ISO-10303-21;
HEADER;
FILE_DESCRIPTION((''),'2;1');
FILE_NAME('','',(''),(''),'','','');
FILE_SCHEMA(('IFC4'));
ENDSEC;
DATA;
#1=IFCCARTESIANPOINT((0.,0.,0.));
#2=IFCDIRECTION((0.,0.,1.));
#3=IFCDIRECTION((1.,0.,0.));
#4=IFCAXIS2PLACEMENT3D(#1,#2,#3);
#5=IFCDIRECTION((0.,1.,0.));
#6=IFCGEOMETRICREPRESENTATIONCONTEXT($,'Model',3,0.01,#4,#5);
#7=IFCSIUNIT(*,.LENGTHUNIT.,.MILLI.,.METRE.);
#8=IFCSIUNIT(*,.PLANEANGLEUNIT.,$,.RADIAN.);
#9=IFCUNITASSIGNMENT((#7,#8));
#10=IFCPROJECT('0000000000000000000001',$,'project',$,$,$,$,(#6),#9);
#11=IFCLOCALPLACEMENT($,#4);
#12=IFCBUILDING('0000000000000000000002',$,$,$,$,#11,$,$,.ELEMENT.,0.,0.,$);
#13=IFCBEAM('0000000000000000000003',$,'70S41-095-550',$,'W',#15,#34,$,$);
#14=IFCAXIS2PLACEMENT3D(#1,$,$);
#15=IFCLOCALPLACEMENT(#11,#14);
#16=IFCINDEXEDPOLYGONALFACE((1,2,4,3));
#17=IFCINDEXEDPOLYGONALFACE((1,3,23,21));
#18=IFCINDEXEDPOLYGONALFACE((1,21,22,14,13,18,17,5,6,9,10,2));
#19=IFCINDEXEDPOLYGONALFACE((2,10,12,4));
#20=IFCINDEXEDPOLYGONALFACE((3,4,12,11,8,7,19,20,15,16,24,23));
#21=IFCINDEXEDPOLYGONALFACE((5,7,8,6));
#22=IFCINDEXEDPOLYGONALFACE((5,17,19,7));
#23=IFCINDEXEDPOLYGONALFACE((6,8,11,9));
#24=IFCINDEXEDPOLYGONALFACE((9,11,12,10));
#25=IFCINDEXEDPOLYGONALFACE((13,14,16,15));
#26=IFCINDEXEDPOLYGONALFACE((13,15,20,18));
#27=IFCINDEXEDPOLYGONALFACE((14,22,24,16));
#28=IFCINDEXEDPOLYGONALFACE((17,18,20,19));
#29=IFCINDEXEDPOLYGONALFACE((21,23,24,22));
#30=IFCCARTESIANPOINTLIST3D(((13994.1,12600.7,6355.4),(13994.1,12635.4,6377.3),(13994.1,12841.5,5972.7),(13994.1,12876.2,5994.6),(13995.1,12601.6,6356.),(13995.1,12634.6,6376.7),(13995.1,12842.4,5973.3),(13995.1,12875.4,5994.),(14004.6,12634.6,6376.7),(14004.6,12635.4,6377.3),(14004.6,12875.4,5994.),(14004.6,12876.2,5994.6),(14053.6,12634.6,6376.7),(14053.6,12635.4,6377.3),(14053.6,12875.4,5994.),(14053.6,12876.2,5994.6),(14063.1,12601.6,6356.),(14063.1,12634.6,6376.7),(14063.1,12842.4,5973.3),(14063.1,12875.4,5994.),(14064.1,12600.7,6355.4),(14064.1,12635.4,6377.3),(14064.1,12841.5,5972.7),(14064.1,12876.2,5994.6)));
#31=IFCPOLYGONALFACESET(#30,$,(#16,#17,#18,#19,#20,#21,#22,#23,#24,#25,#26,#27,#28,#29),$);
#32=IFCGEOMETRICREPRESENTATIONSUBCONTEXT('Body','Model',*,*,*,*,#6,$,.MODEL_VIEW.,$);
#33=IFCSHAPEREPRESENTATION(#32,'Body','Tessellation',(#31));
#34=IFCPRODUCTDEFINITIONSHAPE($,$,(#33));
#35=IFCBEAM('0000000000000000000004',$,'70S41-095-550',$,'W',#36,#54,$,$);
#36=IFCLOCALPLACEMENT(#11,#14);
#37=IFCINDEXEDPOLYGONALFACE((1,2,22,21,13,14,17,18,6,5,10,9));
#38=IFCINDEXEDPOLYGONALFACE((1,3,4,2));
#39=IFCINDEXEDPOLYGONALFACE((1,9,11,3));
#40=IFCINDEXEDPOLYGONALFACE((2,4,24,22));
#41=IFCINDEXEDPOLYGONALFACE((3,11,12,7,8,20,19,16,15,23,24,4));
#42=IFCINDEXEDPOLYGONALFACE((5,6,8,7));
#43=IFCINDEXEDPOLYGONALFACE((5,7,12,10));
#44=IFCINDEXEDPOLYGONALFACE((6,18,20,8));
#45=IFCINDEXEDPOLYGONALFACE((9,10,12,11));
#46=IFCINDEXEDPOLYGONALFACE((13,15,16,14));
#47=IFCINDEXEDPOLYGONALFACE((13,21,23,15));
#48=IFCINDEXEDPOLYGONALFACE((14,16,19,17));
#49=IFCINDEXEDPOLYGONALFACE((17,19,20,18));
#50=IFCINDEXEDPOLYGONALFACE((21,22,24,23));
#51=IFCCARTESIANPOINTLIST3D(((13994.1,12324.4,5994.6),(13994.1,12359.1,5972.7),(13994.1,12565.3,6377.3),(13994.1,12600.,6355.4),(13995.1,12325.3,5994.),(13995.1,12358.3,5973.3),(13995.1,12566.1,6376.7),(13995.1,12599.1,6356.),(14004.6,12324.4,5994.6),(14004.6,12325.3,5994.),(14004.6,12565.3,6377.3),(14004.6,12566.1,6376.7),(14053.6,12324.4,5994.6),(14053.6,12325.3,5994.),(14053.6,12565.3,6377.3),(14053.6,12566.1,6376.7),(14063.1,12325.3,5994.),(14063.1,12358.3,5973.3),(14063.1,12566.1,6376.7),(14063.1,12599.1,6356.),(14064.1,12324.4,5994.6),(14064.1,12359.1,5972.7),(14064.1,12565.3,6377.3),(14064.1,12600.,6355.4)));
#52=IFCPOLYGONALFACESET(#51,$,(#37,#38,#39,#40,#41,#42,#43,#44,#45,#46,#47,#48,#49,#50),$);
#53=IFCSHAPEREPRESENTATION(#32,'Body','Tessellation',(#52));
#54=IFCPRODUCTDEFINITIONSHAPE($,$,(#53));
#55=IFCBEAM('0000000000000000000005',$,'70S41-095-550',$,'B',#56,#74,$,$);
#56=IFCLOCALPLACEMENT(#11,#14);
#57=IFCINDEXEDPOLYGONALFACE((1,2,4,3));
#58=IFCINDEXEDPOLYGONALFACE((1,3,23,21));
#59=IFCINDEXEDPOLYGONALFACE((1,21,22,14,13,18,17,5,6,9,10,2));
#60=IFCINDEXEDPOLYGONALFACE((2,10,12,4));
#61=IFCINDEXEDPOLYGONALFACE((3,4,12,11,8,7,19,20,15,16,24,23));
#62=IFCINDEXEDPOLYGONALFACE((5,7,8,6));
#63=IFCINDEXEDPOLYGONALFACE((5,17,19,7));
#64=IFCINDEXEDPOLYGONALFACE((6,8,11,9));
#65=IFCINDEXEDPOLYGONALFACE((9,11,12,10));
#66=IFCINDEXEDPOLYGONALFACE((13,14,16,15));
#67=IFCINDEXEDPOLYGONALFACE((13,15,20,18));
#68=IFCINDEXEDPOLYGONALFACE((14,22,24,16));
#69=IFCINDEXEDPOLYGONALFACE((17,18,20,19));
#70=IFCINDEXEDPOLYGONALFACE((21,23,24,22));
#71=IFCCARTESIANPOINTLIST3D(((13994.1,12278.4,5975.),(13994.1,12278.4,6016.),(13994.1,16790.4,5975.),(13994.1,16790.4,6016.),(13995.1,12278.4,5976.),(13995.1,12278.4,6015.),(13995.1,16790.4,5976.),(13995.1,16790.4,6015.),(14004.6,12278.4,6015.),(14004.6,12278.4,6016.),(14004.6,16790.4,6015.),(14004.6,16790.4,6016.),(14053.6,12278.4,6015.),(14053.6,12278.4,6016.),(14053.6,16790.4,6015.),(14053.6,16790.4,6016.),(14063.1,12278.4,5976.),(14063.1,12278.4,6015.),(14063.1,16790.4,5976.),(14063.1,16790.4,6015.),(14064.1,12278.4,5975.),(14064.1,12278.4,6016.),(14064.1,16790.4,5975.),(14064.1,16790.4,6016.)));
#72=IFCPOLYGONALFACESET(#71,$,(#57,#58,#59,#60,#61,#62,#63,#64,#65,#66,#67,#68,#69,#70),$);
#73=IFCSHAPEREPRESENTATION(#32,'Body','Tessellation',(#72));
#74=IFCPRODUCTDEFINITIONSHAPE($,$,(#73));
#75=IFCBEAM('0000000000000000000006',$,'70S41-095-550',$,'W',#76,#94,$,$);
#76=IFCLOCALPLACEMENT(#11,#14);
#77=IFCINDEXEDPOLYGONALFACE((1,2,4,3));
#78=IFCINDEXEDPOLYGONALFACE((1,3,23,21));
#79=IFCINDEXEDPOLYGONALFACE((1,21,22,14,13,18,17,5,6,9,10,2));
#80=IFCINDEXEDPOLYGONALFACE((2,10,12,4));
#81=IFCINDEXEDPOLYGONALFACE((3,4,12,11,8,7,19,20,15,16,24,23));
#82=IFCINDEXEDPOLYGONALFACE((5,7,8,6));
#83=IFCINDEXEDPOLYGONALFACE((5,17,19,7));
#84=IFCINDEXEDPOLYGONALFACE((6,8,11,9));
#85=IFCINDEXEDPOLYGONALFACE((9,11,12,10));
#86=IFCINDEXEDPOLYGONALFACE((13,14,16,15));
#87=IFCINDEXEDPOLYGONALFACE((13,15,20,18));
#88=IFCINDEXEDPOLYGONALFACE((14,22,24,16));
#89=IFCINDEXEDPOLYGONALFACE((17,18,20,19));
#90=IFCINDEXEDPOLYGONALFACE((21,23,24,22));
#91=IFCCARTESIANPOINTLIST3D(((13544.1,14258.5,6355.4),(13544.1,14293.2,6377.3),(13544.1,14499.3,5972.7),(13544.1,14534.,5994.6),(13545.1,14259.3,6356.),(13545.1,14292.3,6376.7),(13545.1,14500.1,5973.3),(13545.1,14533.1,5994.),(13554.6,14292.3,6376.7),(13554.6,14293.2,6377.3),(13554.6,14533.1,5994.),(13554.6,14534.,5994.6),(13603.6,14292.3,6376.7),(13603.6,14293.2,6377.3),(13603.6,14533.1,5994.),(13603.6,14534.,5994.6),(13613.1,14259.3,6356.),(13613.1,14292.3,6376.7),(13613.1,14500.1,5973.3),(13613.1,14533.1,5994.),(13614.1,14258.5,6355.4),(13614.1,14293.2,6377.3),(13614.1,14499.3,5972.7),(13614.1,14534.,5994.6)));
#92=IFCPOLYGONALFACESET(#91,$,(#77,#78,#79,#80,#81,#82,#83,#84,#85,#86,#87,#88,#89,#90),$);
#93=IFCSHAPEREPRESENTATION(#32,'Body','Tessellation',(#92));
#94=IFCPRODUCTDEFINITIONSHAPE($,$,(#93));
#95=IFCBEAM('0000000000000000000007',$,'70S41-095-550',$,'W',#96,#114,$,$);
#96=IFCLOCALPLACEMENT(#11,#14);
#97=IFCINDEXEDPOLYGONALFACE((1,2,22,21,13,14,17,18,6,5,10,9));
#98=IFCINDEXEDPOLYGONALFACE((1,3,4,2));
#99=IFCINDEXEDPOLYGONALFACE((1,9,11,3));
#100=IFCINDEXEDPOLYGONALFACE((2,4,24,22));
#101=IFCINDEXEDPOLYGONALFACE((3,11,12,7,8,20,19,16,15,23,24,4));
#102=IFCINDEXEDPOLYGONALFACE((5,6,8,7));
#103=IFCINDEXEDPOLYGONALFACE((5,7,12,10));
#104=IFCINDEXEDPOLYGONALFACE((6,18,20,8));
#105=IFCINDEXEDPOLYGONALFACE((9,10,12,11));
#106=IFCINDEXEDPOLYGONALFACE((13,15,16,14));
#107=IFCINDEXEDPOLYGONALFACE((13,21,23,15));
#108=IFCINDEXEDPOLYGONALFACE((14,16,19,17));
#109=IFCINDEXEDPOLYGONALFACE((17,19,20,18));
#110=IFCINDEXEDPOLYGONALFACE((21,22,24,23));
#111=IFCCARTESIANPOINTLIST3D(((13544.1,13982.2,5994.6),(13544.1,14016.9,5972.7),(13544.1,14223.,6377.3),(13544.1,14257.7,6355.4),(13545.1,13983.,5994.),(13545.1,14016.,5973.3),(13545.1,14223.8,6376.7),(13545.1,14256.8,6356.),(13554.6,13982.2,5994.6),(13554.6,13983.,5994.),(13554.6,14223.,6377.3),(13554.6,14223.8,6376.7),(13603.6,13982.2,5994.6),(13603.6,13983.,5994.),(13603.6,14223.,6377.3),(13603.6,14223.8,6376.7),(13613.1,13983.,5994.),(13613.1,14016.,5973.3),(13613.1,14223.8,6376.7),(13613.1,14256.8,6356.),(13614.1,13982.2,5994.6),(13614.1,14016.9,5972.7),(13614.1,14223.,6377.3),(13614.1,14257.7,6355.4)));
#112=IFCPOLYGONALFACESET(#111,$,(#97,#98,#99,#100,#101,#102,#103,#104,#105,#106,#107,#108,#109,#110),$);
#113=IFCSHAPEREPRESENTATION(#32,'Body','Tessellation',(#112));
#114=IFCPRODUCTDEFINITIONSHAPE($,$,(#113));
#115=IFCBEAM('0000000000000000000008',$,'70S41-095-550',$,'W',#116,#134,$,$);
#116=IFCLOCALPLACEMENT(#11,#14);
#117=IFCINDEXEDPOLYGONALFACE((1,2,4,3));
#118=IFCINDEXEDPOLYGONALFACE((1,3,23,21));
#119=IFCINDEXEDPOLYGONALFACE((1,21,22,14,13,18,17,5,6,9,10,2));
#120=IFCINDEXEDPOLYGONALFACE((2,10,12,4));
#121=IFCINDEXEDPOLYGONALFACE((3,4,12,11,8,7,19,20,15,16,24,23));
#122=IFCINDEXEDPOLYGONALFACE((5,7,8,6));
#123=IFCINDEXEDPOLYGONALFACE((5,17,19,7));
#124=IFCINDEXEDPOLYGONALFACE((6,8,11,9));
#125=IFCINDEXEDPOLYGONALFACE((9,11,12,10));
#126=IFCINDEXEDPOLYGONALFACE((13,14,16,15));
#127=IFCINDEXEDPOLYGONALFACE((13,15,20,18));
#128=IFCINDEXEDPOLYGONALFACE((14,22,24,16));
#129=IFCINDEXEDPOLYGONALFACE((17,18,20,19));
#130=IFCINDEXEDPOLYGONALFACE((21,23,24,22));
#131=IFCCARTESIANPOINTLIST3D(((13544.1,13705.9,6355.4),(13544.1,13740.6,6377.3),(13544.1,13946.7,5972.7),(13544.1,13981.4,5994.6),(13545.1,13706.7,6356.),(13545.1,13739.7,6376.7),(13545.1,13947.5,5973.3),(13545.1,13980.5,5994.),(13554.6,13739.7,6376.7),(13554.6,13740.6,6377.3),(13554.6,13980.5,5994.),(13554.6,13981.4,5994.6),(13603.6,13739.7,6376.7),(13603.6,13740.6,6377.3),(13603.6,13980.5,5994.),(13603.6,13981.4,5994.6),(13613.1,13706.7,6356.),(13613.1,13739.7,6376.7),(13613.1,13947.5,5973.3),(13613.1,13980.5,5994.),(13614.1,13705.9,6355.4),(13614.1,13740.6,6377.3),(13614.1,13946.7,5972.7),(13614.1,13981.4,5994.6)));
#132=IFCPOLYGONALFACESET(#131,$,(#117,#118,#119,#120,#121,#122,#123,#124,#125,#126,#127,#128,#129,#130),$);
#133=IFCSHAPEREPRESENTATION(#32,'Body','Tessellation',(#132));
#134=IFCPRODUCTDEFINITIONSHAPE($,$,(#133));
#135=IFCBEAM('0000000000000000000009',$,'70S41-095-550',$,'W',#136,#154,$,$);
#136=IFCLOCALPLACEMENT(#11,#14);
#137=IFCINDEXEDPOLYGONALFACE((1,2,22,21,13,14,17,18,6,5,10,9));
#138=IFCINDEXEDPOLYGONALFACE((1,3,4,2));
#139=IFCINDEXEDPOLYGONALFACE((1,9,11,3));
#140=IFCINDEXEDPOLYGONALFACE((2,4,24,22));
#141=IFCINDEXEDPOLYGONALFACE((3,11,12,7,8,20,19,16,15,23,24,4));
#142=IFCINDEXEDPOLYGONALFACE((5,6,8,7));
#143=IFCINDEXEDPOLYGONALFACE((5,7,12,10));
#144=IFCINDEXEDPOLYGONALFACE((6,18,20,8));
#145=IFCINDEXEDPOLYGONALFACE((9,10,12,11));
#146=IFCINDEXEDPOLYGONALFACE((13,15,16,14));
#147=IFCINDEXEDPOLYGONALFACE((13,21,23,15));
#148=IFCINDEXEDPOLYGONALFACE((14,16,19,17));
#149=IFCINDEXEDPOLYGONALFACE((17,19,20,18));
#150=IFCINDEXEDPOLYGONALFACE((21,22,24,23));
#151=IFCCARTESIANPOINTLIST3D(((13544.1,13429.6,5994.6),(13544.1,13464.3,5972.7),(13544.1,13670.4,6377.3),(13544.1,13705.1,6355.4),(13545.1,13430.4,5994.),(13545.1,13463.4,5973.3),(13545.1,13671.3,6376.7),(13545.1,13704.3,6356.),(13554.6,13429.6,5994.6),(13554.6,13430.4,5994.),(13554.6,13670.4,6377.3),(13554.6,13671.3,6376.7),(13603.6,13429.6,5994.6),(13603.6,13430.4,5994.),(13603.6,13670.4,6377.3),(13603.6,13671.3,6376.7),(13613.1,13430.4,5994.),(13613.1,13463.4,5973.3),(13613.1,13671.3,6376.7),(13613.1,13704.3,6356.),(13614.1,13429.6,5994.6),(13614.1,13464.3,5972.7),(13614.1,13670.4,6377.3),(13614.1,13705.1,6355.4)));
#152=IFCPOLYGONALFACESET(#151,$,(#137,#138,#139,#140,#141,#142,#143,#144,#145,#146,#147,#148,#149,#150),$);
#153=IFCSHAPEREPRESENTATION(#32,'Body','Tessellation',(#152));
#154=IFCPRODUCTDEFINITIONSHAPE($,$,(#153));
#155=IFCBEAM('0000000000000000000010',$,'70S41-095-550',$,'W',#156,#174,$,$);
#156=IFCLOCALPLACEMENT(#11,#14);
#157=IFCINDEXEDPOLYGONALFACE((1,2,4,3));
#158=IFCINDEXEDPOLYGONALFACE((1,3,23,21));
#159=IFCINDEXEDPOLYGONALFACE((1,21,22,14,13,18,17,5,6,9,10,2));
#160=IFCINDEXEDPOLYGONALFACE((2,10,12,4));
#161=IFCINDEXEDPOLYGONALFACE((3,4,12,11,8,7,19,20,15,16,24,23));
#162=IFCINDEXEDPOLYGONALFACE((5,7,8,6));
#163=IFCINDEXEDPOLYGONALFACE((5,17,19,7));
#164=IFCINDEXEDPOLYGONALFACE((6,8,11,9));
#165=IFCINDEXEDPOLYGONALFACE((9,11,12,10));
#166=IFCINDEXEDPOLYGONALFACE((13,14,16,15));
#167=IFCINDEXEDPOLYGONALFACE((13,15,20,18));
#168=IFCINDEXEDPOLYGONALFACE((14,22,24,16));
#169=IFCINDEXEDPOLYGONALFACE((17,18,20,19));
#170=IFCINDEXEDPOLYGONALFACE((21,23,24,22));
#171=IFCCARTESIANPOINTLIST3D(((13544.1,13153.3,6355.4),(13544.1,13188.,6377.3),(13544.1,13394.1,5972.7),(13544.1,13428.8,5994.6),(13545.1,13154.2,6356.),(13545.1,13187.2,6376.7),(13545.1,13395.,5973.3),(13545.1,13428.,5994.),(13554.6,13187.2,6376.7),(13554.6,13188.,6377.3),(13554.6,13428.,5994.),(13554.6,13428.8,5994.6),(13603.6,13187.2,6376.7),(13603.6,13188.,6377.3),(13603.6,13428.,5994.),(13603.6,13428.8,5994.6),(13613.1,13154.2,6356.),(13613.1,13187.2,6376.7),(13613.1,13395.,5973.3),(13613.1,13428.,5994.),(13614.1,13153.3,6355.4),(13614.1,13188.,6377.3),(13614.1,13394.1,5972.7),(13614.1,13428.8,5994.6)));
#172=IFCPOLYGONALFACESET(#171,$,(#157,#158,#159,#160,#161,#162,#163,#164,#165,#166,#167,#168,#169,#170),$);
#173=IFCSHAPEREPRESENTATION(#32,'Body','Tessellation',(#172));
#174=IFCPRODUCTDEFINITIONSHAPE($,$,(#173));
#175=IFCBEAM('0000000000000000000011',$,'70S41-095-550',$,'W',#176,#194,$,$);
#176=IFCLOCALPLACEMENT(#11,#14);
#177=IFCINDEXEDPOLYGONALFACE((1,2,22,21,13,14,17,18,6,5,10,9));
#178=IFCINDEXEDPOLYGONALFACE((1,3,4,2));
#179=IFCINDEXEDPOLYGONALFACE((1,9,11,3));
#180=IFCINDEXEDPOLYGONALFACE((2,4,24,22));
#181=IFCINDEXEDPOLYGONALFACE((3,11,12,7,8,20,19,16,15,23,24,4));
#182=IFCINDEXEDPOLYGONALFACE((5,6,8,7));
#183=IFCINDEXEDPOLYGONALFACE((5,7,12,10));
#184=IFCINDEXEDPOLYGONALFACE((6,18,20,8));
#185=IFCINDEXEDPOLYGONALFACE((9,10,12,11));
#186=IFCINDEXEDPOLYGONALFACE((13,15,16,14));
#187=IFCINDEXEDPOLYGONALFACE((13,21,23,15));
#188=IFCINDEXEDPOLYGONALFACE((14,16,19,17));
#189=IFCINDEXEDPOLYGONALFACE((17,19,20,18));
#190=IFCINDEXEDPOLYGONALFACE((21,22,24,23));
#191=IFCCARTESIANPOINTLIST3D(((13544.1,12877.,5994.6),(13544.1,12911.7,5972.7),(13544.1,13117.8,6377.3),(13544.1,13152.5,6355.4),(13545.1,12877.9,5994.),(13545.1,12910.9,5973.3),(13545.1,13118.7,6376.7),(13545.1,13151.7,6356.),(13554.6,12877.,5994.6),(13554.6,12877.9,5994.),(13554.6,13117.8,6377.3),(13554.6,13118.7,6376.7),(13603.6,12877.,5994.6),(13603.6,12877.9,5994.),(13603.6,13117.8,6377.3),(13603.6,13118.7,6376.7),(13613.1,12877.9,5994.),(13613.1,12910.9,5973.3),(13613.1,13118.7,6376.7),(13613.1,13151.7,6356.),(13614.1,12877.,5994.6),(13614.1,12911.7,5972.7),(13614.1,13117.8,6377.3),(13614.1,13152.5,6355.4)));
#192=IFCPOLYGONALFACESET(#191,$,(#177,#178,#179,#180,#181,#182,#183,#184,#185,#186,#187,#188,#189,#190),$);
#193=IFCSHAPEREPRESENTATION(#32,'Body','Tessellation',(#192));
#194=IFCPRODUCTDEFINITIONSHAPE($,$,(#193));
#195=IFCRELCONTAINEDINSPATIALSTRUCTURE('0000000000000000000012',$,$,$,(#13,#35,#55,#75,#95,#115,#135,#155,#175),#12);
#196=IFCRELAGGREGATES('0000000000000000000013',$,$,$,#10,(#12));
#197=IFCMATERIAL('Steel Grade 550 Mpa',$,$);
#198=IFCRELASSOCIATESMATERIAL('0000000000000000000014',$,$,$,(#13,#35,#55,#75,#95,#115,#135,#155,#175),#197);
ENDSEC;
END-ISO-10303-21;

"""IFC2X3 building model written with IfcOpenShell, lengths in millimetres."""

from ifc_helpers import new_model, si_unit, direction, frame, origin, origin_with_axes, origin_2d_with_axis, place, context, subcontext, project, spatial, c_section, extrude, source, transform, mapped, material, element, save


model = new_model("IFC2X3")

# Units and contexts
model_context = context("Model", 3, precision=0.01, world=origin_with_axes(), true_north=direction((0.0, 1.0, 0.0)))
body_context = subcontext(model_context, "Body", "Model", "MODEL_VIEW")
ifc_project = project(units=[si_unit("LENGTHUNIT", "METRE", prefix="MILLI"), si_unit("PLANEANGLEUNIT", "RADIAN")], contexts=[model_context])

# Building
building_placement = place(None, origin_with_axes())
building = spatial("IfcBuilding", under=ifc_project, at=building_placement, CompositionType="ELEMENT", ElevationOfRefHeight=0.0, ElevationOfTerrain=0.0)

# Beams
ifc_material = material(Name="Steel Grade 550 Mpa")
shared_shape_1 = source(origin(), body_context, "Body", "SweptSolid", [
    extrude(c_section(Depth=70.0, Width=41.0, WallThickness=1.0, Girth=10.5, at=origin_2d_with_axis()), origin_with_axes(), (0.0, 0.0, 1.0), 452.2),
])
beam_1_placement = place(None, frame((14029.1, 12618.1, 6366.3), z_axis=(0.0, 0.532581, -0.846379), x_axis=(0.0, 0.846379, 0.532581)))
element("IfcBeam", 1, at=beam_1_placement, inside=building, material=ifc_material, Name="70S41-095-550", ObjectType="W", context=body_context, shape_type="MappedRepresentation", body=[
    mapped(shared_shape_1, transform((0.0, 0.0, 0.0), scale=1.0)),
])
shared_shape_2 = source(origin(), body_context, "Body", "SweptSolid", [
    extrude(c_section(Depth=70.0, Width=41.0, WallThickness=1.0, Girth=10.5, at=origin_2d_with_axis()), origin_with_axes(), (0.0, 0.0, 1.0), 452.2),
])
beam_2_placement = place(None, frame((14029.1, 12341.8, 5983.7), z_axis=(0.0, 0.532581, 0.846379), x_axis=(0.0, -0.846379, 0.532581)))
element("IfcBeam", 2, at=beam_2_placement, inside=building, material=ifc_material, Name="70S41-095-550", ObjectType="W", context=body_context, shape_type="MappedRepresentation", body=[
    mapped(shared_shape_2, transform((0.0, 0.0, 0.0), scale=1.0)),
])
shared_shape_3 = source(origin(), body_context, "Body", "SweptSolid", [
    extrude(c_section(Depth=70.0, Width=41.0, WallThickness=1.0, Girth=10.5, at=origin_2d_with_axis()), origin_with_axes(), (0.0, 0.0, 1.0), 4512.0),
])
beam_3_placement = place(None, frame((14029.1, 12278.4, 5995.5), z_axis=(0.0, 1.0, 0.0), x_axis=(0.0, 0.0, 1.0)))
element("IfcBeam", 3, at=beam_3_placement, inside=building, material=ifc_material, Name="70S41-095-550", ObjectType="B", context=body_context, shape_type="MappedRepresentation", body=[
    mapped(shared_shape_3, transform((0.0, 0.0, 0.0), scale=1.0)),
])
shared_shape_4 = source(origin(), body_context, "Body", "SweptSolid", [
    extrude(c_section(Depth=70.0, Width=41.0, WallThickness=1.0, Girth=10.5, at=origin_2d_with_axis()), origin_with_axes(), (0.0, 0.0, 1.0), 452.2),
])
beam_4_placement = place(None, frame((13579.1, 14275.8, 6366.3), z_axis=(0.0, 0.532581, -0.846379), x_axis=(0.0, 0.846379, 0.532581)))
element("IfcBeam", 4, at=beam_4_placement, inside=building, material=ifc_material, Name="70S41-095-550", ObjectType="W", context=body_context, shape_type="MappedRepresentation", body=[
    mapped(shared_shape_4, transform((0.0, 0.0, 0.0), scale=1.0)),
])
shared_shape_5 = source(origin(), body_context, "Body", "SweptSolid", [
    extrude(c_section(Depth=70.0, Width=41.0, WallThickness=1.0, Girth=10.5, at=origin_2d_with_axis()), origin_with_axes(), (0.0, 0.0, 1.0), 452.2),
])
beam_5_placement = place(None, frame((13579.1, 13999.5, 5983.7), z_axis=(0.0, 0.532581, 0.846379), x_axis=(0.0, -0.846379, 0.532581)))
element("IfcBeam", 5, at=beam_5_placement, inside=building, material=ifc_material, Name="70S41-095-550", ObjectType="W", context=body_context, shape_type="MappedRepresentation", body=[
    mapped(shared_shape_5, transform((0.0, 0.0, 0.0), scale=1.0)),
])
shared_shape_6 = source(origin(), body_context, "Body", "SweptSolid", [
    extrude(c_section(Depth=70.0, Width=41.0, WallThickness=1.0, Girth=10.5, at=origin_2d_with_axis()), origin_with_axes(), (0.0, 0.0, 1.0), 452.2),
])
beam_6_placement = place(None, frame((13579.1, 13723.2, 6366.3), z_axis=(0.0, 0.532581, -0.846379), x_axis=(0.0, 0.846379, 0.532581)))
element("IfcBeam", 6, at=beam_6_placement, inside=building, material=ifc_material, Name="70S41-095-550", ObjectType="W", context=body_context, shape_type="MappedRepresentation", body=[
    mapped(shared_shape_6, transform((0.0, 0.0, 0.0), scale=1.0)),
])
shared_shape_7 = source(origin(), body_context, "Body", "SweptSolid", [
    extrude(c_section(Depth=70.0, Width=41.0, WallThickness=1.0, Girth=10.5, at=origin_2d_with_axis()), origin_with_axes(), (0.0, 0.0, 1.0), 452.2),
])
beam_7_placement = place(None, frame((13579.1, 13446.9, 5983.7), z_axis=(0.0, 0.532581, 0.846379), x_axis=(0.0, -0.846379, 0.532581)))
element("IfcBeam", 7, at=beam_7_placement, inside=building, material=ifc_material, Name="70S41-095-550", ObjectType="W", context=body_context, shape_type="MappedRepresentation", body=[
    mapped(shared_shape_7, transform((0.0, 0.0, 0.0), scale=1.0)),
])
shared_shape_8 = source(origin(), body_context, "Body", "SweptSolid", [
    extrude(c_section(Depth=70.0, Width=41.0, WallThickness=1.0, Girth=10.5, at=origin_2d_with_axis()), origin_with_axes(), (0.0, 0.0, 1.0), 452.2),
])
beam_8_placement = place(None, frame((13579.1, 13170.7, 6366.3), z_axis=(0.0, 0.532581, -0.846379), x_axis=(0.0, 0.846379, 0.532581)))
element("IfcBeam", 8, at=beam_8_placement, inside=building, material=ifc_material, Name="70S41-095-550", ObjectType="W", context=body_context, shape_type="MappedRepresentation", body=[
    mapped(shared_shape_8, transform((0.0, 0.0, 0.0), scale=1.0)),
])
shared_shape_9 = source(origin(), body_context, "Body", "SweptSolid", [
    extrude(c_section(Depth=70.0, Width=41.0, WallThickness=1.0, Girth=10.5, at=origin_2d_with_axis()), origin_with_axes(), (0.0, 0.0, 1.0), 452.2),
])
beam_9_placement = place(None, frame((13579.1, 12894.4, 5983.7), z_axis=(0.0, 0.532581, 0.846379), x_axis=(0.0, -0.846379, 0.532581)))
element("IfcBeam", 9, at=beam_9_placement, inside=building, material=ifc_material, Name="70S41-095-550", ObjectType="W", context=body_context, shape_type="MappedRepresentation", body=[
    mapped(shared_shape_9, transform((0.0, 0.0, 0.0), scale=1.0)),
])

save(model, "model.ifc")
